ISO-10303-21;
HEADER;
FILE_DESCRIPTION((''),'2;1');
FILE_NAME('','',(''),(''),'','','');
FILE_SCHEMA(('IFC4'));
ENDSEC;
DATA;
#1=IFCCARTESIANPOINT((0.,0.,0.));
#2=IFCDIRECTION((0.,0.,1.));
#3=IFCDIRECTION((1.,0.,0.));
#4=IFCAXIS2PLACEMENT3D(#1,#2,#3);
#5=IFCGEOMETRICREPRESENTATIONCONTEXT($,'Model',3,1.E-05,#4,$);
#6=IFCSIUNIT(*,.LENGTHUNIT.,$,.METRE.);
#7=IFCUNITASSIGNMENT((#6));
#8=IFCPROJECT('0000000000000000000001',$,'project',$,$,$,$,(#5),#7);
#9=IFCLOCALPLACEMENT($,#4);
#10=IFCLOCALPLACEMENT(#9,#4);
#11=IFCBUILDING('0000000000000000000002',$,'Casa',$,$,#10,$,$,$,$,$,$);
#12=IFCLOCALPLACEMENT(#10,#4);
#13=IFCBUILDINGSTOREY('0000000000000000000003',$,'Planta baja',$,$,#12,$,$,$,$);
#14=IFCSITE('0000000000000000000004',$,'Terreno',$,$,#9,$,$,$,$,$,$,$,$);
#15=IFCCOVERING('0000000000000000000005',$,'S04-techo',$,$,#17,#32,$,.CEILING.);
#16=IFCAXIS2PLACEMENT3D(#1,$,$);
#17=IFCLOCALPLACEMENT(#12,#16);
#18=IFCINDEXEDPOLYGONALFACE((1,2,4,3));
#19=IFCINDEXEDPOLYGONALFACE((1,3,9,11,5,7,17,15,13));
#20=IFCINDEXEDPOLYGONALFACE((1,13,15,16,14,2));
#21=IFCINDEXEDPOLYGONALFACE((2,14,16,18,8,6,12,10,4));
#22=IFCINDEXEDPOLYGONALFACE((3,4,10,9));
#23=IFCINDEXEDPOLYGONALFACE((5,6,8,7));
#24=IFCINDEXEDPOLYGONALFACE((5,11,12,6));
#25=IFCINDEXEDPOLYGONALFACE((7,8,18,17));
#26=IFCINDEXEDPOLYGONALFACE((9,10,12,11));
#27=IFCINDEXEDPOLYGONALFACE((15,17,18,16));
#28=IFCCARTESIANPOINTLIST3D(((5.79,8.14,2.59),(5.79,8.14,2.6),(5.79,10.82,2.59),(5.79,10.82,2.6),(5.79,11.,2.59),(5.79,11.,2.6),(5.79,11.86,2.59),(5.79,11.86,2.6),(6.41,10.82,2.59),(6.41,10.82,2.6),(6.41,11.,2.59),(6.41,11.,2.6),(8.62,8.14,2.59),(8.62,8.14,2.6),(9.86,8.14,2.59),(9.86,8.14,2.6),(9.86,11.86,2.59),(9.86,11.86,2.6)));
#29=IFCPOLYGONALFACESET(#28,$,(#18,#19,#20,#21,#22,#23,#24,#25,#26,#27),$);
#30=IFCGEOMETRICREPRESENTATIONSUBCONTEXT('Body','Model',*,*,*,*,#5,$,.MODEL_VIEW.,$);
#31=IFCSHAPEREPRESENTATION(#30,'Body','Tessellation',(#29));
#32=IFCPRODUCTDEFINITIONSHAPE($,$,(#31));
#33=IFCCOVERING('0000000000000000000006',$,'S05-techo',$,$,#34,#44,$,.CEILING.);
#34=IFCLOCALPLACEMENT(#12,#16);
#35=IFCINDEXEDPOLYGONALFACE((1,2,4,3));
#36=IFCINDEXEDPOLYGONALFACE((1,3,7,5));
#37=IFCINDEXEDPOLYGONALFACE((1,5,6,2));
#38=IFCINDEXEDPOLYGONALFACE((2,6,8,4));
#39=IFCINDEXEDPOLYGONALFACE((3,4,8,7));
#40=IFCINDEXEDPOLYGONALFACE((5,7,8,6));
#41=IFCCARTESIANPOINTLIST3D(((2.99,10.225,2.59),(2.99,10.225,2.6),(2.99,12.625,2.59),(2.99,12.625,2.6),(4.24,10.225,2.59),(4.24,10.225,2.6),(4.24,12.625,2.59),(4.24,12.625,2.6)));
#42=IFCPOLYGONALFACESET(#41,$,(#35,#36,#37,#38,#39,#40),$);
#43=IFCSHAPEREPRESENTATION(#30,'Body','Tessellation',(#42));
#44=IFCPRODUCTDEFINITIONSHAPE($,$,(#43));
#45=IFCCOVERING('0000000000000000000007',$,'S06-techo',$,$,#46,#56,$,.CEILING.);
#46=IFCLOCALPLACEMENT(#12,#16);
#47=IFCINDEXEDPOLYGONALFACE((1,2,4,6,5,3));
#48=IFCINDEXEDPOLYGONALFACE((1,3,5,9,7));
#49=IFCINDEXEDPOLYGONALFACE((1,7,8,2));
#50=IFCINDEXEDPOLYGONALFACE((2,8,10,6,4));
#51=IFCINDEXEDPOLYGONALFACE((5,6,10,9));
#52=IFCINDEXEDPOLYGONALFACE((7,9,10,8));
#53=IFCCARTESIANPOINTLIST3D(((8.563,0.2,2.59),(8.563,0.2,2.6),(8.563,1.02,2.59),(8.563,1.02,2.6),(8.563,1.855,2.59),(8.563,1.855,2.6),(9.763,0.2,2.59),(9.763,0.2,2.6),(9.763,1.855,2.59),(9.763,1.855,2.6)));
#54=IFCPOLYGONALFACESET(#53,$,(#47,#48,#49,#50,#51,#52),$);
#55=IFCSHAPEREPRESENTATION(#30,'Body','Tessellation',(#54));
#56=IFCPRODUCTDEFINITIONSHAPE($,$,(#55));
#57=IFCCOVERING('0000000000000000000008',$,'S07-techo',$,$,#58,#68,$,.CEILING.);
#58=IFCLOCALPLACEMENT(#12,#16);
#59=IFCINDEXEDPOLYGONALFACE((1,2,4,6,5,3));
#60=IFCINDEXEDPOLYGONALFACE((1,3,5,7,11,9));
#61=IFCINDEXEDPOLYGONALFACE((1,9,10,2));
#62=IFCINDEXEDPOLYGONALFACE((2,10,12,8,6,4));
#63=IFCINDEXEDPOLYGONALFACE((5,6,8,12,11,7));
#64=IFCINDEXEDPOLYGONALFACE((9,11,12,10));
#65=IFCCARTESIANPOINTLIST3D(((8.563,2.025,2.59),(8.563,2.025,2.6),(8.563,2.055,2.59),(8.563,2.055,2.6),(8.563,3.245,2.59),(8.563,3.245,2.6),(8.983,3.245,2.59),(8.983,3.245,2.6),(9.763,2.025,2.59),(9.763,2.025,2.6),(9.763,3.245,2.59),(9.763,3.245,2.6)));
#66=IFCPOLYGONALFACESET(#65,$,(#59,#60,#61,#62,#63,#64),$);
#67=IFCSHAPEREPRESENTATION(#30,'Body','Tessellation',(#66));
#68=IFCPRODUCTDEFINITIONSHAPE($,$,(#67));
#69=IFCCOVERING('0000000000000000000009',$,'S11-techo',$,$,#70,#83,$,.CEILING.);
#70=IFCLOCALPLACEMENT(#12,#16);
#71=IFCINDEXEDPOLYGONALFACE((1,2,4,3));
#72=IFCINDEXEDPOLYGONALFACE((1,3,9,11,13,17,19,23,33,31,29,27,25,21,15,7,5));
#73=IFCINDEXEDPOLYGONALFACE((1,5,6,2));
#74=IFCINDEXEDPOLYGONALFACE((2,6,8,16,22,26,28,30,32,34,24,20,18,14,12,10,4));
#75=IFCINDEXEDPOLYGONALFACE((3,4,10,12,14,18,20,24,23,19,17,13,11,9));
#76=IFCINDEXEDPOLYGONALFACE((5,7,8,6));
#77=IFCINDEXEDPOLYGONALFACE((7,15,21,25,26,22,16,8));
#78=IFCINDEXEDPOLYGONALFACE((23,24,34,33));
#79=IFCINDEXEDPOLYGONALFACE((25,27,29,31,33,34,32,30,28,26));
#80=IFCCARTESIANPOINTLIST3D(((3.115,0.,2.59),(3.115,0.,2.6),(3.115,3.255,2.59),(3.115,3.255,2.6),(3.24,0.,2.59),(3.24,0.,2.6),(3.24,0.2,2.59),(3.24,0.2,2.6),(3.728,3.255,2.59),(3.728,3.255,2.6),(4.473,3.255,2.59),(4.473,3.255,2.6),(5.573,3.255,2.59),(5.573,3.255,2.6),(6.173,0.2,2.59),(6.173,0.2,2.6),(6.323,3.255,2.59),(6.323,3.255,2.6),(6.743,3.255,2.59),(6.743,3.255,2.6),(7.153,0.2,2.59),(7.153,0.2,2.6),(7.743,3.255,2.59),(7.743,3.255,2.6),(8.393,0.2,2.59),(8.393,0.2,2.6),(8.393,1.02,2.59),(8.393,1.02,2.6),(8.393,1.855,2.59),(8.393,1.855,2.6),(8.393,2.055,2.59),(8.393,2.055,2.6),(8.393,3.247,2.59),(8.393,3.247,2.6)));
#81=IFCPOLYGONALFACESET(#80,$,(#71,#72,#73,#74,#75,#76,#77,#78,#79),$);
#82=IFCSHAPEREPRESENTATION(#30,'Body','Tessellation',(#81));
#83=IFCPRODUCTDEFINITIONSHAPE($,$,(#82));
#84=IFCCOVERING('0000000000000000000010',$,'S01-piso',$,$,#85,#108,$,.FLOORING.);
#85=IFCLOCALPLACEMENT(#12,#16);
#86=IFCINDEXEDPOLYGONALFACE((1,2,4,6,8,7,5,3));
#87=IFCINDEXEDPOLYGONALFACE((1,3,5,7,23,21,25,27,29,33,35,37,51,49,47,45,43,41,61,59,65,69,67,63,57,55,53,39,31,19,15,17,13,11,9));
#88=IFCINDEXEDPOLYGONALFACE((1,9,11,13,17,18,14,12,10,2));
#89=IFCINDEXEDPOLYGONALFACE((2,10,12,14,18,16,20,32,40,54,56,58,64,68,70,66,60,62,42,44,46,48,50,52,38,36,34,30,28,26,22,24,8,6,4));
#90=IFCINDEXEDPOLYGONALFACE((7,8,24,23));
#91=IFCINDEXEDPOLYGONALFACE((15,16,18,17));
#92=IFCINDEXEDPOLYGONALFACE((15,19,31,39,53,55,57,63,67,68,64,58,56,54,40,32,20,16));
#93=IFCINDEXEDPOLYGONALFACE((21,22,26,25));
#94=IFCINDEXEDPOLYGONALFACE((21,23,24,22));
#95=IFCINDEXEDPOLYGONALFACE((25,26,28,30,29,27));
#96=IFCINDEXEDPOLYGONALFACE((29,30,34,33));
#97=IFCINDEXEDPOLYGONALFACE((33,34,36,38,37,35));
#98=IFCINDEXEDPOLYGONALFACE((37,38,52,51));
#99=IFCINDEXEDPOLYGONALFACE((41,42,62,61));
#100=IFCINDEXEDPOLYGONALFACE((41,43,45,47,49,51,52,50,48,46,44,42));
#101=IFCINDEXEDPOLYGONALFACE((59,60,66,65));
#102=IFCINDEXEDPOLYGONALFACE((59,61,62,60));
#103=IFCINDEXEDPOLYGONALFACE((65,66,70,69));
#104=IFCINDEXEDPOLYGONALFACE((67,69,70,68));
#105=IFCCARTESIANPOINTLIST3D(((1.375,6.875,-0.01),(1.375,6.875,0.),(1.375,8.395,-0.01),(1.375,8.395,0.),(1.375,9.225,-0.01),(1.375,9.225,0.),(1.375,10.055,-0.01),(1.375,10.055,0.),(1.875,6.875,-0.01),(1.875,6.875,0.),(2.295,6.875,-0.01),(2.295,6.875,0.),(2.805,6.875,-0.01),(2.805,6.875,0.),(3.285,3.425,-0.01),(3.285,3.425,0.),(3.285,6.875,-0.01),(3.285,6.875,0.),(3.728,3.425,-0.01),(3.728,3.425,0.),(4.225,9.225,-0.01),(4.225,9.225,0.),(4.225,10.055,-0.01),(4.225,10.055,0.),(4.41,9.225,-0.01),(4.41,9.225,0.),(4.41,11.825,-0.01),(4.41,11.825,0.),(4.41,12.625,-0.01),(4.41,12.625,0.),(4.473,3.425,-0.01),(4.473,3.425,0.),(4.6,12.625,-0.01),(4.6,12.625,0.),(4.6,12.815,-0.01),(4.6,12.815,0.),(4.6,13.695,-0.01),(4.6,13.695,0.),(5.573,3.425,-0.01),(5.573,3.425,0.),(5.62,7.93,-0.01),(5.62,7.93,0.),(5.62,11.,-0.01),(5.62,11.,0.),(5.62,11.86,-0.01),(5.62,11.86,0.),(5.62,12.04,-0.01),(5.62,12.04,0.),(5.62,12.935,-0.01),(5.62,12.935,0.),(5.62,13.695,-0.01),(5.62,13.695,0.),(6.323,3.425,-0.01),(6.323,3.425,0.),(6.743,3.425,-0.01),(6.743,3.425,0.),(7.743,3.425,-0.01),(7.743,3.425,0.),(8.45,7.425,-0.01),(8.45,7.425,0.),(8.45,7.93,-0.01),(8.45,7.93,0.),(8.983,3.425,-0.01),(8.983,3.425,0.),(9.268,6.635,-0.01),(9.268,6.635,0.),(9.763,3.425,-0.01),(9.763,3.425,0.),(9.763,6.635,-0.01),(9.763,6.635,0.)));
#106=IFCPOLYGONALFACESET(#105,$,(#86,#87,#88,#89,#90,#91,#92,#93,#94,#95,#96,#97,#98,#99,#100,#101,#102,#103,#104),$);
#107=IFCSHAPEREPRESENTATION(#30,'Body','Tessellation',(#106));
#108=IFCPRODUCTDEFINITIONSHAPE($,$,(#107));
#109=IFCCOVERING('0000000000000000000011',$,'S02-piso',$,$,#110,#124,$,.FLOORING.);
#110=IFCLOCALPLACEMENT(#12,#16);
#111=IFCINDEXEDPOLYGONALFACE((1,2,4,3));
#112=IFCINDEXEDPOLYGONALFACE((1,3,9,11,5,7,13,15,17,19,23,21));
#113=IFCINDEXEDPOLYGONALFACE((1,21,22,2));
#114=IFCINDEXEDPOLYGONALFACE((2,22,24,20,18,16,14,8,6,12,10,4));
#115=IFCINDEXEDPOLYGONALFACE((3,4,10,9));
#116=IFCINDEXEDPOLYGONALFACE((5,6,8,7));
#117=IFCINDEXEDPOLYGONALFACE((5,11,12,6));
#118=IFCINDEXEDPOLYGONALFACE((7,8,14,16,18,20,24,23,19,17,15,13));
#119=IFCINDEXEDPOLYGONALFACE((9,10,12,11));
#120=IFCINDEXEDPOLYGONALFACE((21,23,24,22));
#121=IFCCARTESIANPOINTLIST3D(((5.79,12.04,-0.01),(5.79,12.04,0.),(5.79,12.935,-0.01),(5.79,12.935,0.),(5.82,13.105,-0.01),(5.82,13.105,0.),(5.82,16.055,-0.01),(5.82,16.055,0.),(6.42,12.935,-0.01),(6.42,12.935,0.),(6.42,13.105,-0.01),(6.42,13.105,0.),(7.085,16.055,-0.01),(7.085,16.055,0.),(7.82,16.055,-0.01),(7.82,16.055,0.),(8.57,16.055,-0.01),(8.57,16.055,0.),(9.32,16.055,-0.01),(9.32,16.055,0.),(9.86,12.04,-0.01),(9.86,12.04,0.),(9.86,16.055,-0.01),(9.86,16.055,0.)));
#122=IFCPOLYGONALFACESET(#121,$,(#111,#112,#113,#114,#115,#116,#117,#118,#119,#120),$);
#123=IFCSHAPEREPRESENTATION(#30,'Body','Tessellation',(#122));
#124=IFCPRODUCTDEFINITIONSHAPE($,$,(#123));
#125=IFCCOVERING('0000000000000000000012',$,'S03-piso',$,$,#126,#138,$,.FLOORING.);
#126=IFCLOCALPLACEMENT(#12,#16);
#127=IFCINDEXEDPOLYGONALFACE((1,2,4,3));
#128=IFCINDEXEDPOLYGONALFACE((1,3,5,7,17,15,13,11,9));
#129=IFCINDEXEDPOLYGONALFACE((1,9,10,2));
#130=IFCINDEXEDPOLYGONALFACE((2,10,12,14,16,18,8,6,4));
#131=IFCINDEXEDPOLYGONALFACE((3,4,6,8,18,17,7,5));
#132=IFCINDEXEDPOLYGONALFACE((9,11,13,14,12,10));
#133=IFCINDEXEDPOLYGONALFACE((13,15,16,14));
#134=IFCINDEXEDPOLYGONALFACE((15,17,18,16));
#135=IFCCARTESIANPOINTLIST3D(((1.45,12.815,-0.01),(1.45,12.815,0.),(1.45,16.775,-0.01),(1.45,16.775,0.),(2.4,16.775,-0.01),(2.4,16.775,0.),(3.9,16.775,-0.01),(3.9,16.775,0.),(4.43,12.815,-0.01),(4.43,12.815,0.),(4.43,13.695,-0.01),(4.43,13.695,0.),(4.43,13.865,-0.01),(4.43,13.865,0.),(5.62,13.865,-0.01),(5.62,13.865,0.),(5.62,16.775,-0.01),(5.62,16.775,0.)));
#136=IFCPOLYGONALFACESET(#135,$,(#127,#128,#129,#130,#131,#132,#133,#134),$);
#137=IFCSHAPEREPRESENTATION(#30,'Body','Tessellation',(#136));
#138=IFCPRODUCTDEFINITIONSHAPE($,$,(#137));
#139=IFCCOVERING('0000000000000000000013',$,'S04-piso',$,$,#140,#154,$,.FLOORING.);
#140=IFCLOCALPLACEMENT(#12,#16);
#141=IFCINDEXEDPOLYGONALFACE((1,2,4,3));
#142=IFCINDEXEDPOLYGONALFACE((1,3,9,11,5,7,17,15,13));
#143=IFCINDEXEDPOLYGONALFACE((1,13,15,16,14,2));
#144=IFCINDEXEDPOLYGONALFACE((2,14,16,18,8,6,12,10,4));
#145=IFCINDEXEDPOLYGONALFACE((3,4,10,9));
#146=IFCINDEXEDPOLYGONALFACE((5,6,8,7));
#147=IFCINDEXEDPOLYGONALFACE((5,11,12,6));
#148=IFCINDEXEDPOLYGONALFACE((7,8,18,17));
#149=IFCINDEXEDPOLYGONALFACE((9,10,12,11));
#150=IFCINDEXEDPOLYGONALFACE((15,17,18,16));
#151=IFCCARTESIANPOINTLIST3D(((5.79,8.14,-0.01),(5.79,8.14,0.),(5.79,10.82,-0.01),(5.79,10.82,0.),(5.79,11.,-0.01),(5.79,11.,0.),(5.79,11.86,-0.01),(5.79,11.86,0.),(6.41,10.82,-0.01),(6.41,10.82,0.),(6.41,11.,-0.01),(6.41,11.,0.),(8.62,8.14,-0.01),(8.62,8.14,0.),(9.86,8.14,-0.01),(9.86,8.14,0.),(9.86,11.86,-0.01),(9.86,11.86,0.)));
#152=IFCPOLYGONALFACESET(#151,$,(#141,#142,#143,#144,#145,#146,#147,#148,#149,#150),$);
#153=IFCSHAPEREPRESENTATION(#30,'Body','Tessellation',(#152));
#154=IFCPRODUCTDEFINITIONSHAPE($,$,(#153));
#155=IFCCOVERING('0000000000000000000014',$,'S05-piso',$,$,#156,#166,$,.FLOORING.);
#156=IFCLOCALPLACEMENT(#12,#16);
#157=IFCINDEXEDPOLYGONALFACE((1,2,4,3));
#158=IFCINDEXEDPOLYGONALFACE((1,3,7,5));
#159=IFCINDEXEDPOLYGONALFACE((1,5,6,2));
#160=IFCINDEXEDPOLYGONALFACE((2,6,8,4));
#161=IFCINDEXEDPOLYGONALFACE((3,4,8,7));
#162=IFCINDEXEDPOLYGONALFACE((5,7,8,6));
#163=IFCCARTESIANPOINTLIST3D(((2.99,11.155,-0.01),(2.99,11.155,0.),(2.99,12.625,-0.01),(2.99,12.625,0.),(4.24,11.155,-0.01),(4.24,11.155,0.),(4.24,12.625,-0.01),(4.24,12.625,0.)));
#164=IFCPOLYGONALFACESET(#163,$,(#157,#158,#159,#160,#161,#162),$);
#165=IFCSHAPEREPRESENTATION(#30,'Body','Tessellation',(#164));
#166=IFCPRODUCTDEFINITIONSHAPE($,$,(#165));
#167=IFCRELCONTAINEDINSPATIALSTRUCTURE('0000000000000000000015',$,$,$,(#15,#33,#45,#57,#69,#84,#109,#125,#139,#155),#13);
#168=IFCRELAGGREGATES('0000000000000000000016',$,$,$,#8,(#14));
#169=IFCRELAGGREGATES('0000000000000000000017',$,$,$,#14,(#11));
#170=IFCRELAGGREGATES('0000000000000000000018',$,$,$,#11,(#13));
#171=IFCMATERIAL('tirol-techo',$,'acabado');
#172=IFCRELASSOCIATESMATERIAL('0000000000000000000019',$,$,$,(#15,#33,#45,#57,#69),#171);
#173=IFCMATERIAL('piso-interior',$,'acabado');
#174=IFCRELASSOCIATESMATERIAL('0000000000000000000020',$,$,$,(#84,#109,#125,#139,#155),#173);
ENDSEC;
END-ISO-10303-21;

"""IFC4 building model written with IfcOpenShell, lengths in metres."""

from ifc_helpers import new_model, si_unit, frame, origin_with_axes, place, context, subcontext, project, spatial, line, indexed_curve, outline, extrude, material, element, save


model = new_model("IFC4")

# Units and contexts
model_context = context("Model", 3, precision=1e-05, world=origin_with_axes())
body_context = subcontext(model_context, "Body", "Model", "MODEL_VIEW")
ifc_project = project(units=[si_unit("LENGTHUNIT", "METRE")], contexts=[model_context])

# Site, building, storey
site_placement = place(None, origin_with_axes())
site = spatial("IfcSite", under=ifc_project, at=site_placement, Name="Terreno")
building_placement = place(site_placement, origin_with_axes())
building = spatial("IfcBuilding", under=site, at=building_placement, Name="Casa")
storey_placement = place(building_placement, origin_with_axes())
storey = spatial("IfcBuildingStorey", under=building, at=storey_placement, Name="Planta baja")

# Coverings
ifc_material_1 = material(Name="tirol-techo", Category="acabado")
covering_1_placement = place(storey_placement, origin_with_axes())
element("IfcCovering", 1, at=covering_1_placement, inside=storey, material=ifc_material_1, Name="S04-techo", PredefinedType="CEILING", context=body_context, shape_type="SweptSolid", body=[
    extrude(outline(indexed_curve([(6.41, 10.82), (6.41, 11.0), (5.79, 11.0), (5.79, 11.86), (9.86, 11.86), (9.86, 8.14), (8.62, 8.14), (5.79, 8.14), (5.79, 10.82)], segments=[line(1, 2, 3, 4, 5, 6, 7, 8, 9, 1)])), frame((0.0, 0.0, 2.59), z_axis=(0.0, 0.0, 1.0), x_axis=(1.0, 0.0, 0.0)), (0.0, 0.0, 1.0), 0.01),
])
covering_2_placement = place(storey_placement, origin_with_axes())
element("IfcCovering", 2, at=covering_2_placement, inside=storey, material=ifc_material_1, Name="S05-techo", PredefinedType="CEILING", context=body_context, shape_type="SweptSolid", body=[
    extrude(outline(indexed_curve([(2.99, 12.625), (4.24, 12.625), (4.24, 10.225), (2.99, 10.225)], segments=[line(1, 2, 3, 4, 1)])), frame((0.0, 0.0, 2.59), z_axis=(0.0, 0.0, 1.0), x_axis=(1.0, 0.0, 0.0)), (0.0, 0.0, 1.0), 0.01),
])
covering_3_placement = place(storey_placement, origin_with_axes())
element("IfcCovering", 3, at=covering_3_placement, inside=storey, material=ifc_material_1, Name="S06-techo", PredefinedType="CEILING", context=body_context, shape_type="SweptSolid", body=[
    extrude(outline(indexed_curve([(8.563, 0.2), (8.563, 1.02), (8.563, 1.855), (9.763, 1.855), (9.763, 0.2)], segments=[line(1, 2, 3, 4, 5, 1)])), frame((0.0, 0.0, 2.59), z_axis=(0.0, 0.0, 1.0), x_axis=(1.0, 0.0, 0.0)), (0.0, 0.0, 1.0), 0.01),
])
covering_4_placement = place(storey_placement, origin_with_axes())
element("IfcCovering", 4, at=covering_4_placement, inside=storey, material=ifc_material_1, Name="S07-techo", PredefinedType="CEILING", context=body_context, shape_type="SweptSolid", body=[
    extrude(outline(indexed_curve([(8.563, 3.245), (8.983, 3.245), (9.763, 3.245), (9.763, 2.025), (8.563, 2.025), (8.563, 2.055)], segments=[line(1, 2, 3, 4, 5, 6, 1)])), frame((0.0, 0.0, 2.59), z_axis=(0.0, 0.0, 1.0), x_axis=(1.0, 0.0, 0.0)), (0.0, 0.0, 1.0), 0.01),
])
covering_5_placement = place(storey_placement, origin_with_axes())
element("IfcCovering", 5, at=covering_5_placement, inside=storey, material=ifc_material_1, Name="S11-techo", PredefinedType="CEILING", context=body_context, shape_type="SweptSolid", body=[
    extrude(outline(indexed_curve([(5.573, 3.255), (6.323, 3.255), (6.743, 3.255), (7.743, 3.255), (8.393, 3.247), (8.393, 2.055), (8.393, 1.855), (8.393, 1.02), (8.393, 0.2), (7.153, 0.2), (6.173, 0.2), (3.24, 0.2), (3.24, 0.0), (3.115, 0.0), (3.115, 3.255), (3.728, 3.255), (4.473, 3.255)], segments=[line(1, 2, 3, 4, 5, 6, 7, 8, 9, 10, 11, 12, 13, 14, 15, 16, 17, 1)])), frame((0.0, 0.0, 2.59), z_axis=(0.0, 0.0, 1.0), x_axis=(1.0, 0.0, 0.0)), (0.0, 0.0, 1.0), 0.01),
])
ifc_material_2 = material(Name="piso-interior", Category="acabado")
covering_6_placement = place(storey_placement, origin_with_axes())
element("IfcCovering", 6, at=covering_6_placement, inside=storey, material=ifc_material_2, Name="S01-piso", PredefinedType="FLOORING", context=body_context, shape_type="SweptSolid", body=[
    extrude(outline(indexed_curve([(4.6, 12.815), (4.6, 13.695), (5.62, 13.695), (5.62, 12.935), (5.62, 12.04), (5.62, 11.86), (5.62, 11.0), (5.62, 7.93), (8.45, 7.93), (8.45, 7.425), (9.268, 6.635), (9.763, 6.635), (9.763, 3.425), (8.983, 3.425), (7.743, 3.425), (6.743, 3.425), (6.323, 3.425), (5.573, 3.425), (4.473, 3.425), (3.728, 3.425), (3.285, 3.425), (3.285, 6.875), (2.805, 6.875), (2.295, 6.875), (1.875, 6.875), (1.375, 6.875), (1.375, 8.395), (1.375, 9.225), (1.375, 10.055), (4.225, 10.055), (4.225, 9.225), (4.41, 9.225), (4.41, 11.825), (4.41, 12.625), (4.6, 12.625)], segments=[line(1, 2, 3, 4, 5, 6, 7, 8, 9, 10, 11, 12, 13, 14, 15, 16, 17, 18, 19, 20, 21, 22, 23, 24, 25, 26, 27, 28, 29, 30, 31, 32, 33, 34, 35, 1)])), frame((0.0, 0.0, -0.01), z_axis=(0.0, 0.0, 1.0), x_axis=(1.0, 0.0, 0.0)), (0.0, 0.0, 1.0), 0.01),
])
covering_7_placement = place(storey_placement, origin_with_axes())
element("IfcCovering", 7, at=covering_7_placement, inside=storey, material=ifc_material_2, Name="S02-piso", PredefinedType="FLOORING", context=body_context, shape_type="SweptSolid", body=[
    extrude(outline(indexed_curve([(6.42, 12.935), (6.42, 13.105), (5.82, 13.105), (5.82, 16.055), (7.085, 16.055), (7.82, 16.055), (8.57, 16.055), (9.32, 16.055), (9.86, 16.055), (9.86, 12.04), (5.79, 12.04), (5.79, 12.935)], segments=[line(1, 2, 3, 4, 5, 6, 7, 8, 9, 10, 11, 12, 1)])), frame((0.0, 0.0, -0.01), z_axis=(0.0, 0.0, 1.0), x_axis=(1.0, 0.0, 0.0)), (0.0, 0.0, 1.0), 0.01),
])
covering_8_placement = place(storey_placement, origin_with_axes())
element("IfcCovering", 8, at=covering_8_placement, inside=storey, material=ifc_material_2, Name="S03-piso", PredefinedType="FLOORING", context=body_context, shape_type="SweptSolid", body=[
    extrude(outline(indexed_curve([(2.4, 16.775), (3.9, 16.775), (5.62, 16.775), (5.62, 13.865), (4.43, 13.865), (4.43, 13.695), (4.43, 12.815), (1.45, 12.815), (1.45, 16.775)], segments=[line(1, 2, 3, 4, 5, 6, 7, 8, 9, 1)])), frame((0.0, 0.0, -0.01), z_axis=(0.0, 0.0, 1.0), x_axis=(1.0, 0.0, 0.0)), (0.0, 0.0, 1.0), 0.01),
])
covering_9_placement = place(storey_placement, origin_with_axes())
element("IfcCovering", 9, at=covering_9_placement, inside=storey, material=ifc_material_2, Name="S04-piso", PredefinedType="FLOORING", context=body_context, shape_type="SweptSolid", body=[
    extrude(outline(indexed_curve([(6.41, 11.0), (5.79, 11.0), (5.79, 11.86), (9.86, 11.86), (9.86, 8.14), (8.62, 8.14), (5.79, 8.14), (5.79, 10.82), (6.41, 10.82)], segments=[line(1, 2, 3, 4, 5, 6, 7, 8, 9, 1)])), frame((0.0, 0.0, -0.01), z_axis=(0.0, 0.0, 1.0), x_axis=(1.0, 0.0, 0.0)), (0.0, 0.0, 1.0), 0.01),
])
covering_10_placement = place(storey_placement, origin_with_axes())
element("IfcCovering", 10, at=covering_10_placement, inside=storey, material=ifc_material_2, Name="S05-piso", PredefinedType="FLOORING", context=body_context, shape_type="SweptSolid", body=[
    extrude(outline(indexed_curve([(4.24, 12.625), (4.24, 11.155), (2.99, 11.155), (2.99, 12.625)], segments=[line(1, 2, 3, 4, 1)])), frame((0.0, 0.0, -0.01), z_axis=(0.0, 0.0, 1.0), x_axis=(1.0, 0.0, 0.0)), (0.0, 0.0, 1.0), 0.01),
])

save(model, "model.ifc")
